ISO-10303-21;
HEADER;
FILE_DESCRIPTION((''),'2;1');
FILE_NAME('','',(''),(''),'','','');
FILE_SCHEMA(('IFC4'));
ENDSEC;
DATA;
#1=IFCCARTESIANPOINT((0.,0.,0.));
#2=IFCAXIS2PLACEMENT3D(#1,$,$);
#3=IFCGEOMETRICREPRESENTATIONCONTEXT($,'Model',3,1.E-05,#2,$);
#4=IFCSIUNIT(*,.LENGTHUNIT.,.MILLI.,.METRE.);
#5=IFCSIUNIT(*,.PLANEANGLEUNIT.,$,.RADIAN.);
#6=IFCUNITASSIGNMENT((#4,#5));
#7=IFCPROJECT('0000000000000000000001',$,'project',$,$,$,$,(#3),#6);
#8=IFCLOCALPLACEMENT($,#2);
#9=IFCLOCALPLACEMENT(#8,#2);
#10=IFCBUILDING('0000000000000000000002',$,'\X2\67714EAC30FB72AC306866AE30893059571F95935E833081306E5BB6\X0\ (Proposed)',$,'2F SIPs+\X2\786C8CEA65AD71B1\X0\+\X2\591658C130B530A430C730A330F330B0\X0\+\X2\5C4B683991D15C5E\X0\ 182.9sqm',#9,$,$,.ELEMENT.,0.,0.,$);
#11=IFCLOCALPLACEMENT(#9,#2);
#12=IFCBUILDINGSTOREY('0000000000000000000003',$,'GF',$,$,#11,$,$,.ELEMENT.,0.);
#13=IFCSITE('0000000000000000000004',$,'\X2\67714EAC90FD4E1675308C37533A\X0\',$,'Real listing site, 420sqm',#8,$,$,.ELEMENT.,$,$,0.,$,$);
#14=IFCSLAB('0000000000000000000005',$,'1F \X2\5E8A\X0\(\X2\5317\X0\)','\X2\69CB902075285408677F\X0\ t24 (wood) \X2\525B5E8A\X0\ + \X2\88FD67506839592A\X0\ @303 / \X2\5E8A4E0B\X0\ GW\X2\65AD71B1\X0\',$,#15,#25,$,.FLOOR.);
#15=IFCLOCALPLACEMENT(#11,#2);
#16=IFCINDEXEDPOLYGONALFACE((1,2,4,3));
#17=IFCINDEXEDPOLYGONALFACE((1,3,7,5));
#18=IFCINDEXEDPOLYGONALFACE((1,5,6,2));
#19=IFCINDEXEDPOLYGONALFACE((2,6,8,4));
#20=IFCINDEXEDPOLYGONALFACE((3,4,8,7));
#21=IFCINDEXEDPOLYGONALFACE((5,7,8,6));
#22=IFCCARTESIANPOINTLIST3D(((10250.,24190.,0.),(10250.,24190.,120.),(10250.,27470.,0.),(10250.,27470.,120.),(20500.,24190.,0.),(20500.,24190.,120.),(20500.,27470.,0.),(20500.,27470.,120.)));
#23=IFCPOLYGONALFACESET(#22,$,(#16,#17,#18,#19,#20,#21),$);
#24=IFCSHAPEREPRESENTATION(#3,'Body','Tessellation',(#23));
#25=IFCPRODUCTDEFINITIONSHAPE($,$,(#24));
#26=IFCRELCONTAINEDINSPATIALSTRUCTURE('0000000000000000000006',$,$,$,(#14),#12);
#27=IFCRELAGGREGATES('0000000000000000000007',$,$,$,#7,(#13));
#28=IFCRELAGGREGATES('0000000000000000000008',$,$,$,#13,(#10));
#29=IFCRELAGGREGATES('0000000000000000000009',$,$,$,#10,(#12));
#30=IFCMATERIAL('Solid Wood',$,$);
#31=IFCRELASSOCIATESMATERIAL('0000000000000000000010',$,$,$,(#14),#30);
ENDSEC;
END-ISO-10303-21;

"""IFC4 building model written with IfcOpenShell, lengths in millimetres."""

from ifc_helpers import new_model, si_unit, frame, frame_2d, origin, place, context, project, spatial, rectangle, extrude, material, element, save


model = new_model("IFC4")

# Units and contexts
model_context = context("Model", 3, precision=1e-05, world=origin())
ifc_project = project(units=[si_unit("LENGTHUNIT", "METRE", prefix="MILLI"), si_unit("PLANEANGLEUNIT", "RADIAN")], contexts=[model_context])

# Site, building, storey
site_placement = place(None, origin())
site = spatial("IfcSite", under=ifc_project, at=site_placement, Name="東京都世田谷区", ObjectType="Real listing site, 420sqm", CompositionType="ELEMENT", RefElevation=0.0)
building_placement = place(site_placement, origin())
building = spatial("IfcBuilding", under=site, at=building_placement, Name="東京・犬と暮らす土間広めの家 (Proposed)", ObjectType="2F SIPs+硬質断熱+外壁サイディング+屋根金属 182.9sqm", CompositionType="ELEMENT", ElevationOfRefHeight=0.0, ElevationOfTerrain=0.0)
storey_placement = place(building_placement, origin())
storey = spatial("IfcBuildingStorey", under=building, at=storey_placement, Name="GF", CompositionType="ELEMENT", Elevation=0.0)

# Shared definitions
ifc_material_1 = material(Name="Solid Wood")

# Slab
slab_1_placement = place(storey_placement, frame((5125.0, 12095.0, 0.0)))
element("IfcSlab", 1, at=slab_1_placement, inside=storey, material=ifc_material_1, Name="1F 床(北)", Description="構造用合板 t24 (wood) 剛床 + 製材根太 @303 / 床下 GW断熱", PredefinedType="FLOOR", context=model_context, shape_type="SweptSolid", body=[
    extrude(rectangle(XDim=10250.0, YDim=3280.0, at=frame_2d((5125.0, 1640.0))), frame((5125.0, 12095.0, 0.0)), (0.0, 0.0, 1.0), 120.0),
])

save(model, "model.ifc")
